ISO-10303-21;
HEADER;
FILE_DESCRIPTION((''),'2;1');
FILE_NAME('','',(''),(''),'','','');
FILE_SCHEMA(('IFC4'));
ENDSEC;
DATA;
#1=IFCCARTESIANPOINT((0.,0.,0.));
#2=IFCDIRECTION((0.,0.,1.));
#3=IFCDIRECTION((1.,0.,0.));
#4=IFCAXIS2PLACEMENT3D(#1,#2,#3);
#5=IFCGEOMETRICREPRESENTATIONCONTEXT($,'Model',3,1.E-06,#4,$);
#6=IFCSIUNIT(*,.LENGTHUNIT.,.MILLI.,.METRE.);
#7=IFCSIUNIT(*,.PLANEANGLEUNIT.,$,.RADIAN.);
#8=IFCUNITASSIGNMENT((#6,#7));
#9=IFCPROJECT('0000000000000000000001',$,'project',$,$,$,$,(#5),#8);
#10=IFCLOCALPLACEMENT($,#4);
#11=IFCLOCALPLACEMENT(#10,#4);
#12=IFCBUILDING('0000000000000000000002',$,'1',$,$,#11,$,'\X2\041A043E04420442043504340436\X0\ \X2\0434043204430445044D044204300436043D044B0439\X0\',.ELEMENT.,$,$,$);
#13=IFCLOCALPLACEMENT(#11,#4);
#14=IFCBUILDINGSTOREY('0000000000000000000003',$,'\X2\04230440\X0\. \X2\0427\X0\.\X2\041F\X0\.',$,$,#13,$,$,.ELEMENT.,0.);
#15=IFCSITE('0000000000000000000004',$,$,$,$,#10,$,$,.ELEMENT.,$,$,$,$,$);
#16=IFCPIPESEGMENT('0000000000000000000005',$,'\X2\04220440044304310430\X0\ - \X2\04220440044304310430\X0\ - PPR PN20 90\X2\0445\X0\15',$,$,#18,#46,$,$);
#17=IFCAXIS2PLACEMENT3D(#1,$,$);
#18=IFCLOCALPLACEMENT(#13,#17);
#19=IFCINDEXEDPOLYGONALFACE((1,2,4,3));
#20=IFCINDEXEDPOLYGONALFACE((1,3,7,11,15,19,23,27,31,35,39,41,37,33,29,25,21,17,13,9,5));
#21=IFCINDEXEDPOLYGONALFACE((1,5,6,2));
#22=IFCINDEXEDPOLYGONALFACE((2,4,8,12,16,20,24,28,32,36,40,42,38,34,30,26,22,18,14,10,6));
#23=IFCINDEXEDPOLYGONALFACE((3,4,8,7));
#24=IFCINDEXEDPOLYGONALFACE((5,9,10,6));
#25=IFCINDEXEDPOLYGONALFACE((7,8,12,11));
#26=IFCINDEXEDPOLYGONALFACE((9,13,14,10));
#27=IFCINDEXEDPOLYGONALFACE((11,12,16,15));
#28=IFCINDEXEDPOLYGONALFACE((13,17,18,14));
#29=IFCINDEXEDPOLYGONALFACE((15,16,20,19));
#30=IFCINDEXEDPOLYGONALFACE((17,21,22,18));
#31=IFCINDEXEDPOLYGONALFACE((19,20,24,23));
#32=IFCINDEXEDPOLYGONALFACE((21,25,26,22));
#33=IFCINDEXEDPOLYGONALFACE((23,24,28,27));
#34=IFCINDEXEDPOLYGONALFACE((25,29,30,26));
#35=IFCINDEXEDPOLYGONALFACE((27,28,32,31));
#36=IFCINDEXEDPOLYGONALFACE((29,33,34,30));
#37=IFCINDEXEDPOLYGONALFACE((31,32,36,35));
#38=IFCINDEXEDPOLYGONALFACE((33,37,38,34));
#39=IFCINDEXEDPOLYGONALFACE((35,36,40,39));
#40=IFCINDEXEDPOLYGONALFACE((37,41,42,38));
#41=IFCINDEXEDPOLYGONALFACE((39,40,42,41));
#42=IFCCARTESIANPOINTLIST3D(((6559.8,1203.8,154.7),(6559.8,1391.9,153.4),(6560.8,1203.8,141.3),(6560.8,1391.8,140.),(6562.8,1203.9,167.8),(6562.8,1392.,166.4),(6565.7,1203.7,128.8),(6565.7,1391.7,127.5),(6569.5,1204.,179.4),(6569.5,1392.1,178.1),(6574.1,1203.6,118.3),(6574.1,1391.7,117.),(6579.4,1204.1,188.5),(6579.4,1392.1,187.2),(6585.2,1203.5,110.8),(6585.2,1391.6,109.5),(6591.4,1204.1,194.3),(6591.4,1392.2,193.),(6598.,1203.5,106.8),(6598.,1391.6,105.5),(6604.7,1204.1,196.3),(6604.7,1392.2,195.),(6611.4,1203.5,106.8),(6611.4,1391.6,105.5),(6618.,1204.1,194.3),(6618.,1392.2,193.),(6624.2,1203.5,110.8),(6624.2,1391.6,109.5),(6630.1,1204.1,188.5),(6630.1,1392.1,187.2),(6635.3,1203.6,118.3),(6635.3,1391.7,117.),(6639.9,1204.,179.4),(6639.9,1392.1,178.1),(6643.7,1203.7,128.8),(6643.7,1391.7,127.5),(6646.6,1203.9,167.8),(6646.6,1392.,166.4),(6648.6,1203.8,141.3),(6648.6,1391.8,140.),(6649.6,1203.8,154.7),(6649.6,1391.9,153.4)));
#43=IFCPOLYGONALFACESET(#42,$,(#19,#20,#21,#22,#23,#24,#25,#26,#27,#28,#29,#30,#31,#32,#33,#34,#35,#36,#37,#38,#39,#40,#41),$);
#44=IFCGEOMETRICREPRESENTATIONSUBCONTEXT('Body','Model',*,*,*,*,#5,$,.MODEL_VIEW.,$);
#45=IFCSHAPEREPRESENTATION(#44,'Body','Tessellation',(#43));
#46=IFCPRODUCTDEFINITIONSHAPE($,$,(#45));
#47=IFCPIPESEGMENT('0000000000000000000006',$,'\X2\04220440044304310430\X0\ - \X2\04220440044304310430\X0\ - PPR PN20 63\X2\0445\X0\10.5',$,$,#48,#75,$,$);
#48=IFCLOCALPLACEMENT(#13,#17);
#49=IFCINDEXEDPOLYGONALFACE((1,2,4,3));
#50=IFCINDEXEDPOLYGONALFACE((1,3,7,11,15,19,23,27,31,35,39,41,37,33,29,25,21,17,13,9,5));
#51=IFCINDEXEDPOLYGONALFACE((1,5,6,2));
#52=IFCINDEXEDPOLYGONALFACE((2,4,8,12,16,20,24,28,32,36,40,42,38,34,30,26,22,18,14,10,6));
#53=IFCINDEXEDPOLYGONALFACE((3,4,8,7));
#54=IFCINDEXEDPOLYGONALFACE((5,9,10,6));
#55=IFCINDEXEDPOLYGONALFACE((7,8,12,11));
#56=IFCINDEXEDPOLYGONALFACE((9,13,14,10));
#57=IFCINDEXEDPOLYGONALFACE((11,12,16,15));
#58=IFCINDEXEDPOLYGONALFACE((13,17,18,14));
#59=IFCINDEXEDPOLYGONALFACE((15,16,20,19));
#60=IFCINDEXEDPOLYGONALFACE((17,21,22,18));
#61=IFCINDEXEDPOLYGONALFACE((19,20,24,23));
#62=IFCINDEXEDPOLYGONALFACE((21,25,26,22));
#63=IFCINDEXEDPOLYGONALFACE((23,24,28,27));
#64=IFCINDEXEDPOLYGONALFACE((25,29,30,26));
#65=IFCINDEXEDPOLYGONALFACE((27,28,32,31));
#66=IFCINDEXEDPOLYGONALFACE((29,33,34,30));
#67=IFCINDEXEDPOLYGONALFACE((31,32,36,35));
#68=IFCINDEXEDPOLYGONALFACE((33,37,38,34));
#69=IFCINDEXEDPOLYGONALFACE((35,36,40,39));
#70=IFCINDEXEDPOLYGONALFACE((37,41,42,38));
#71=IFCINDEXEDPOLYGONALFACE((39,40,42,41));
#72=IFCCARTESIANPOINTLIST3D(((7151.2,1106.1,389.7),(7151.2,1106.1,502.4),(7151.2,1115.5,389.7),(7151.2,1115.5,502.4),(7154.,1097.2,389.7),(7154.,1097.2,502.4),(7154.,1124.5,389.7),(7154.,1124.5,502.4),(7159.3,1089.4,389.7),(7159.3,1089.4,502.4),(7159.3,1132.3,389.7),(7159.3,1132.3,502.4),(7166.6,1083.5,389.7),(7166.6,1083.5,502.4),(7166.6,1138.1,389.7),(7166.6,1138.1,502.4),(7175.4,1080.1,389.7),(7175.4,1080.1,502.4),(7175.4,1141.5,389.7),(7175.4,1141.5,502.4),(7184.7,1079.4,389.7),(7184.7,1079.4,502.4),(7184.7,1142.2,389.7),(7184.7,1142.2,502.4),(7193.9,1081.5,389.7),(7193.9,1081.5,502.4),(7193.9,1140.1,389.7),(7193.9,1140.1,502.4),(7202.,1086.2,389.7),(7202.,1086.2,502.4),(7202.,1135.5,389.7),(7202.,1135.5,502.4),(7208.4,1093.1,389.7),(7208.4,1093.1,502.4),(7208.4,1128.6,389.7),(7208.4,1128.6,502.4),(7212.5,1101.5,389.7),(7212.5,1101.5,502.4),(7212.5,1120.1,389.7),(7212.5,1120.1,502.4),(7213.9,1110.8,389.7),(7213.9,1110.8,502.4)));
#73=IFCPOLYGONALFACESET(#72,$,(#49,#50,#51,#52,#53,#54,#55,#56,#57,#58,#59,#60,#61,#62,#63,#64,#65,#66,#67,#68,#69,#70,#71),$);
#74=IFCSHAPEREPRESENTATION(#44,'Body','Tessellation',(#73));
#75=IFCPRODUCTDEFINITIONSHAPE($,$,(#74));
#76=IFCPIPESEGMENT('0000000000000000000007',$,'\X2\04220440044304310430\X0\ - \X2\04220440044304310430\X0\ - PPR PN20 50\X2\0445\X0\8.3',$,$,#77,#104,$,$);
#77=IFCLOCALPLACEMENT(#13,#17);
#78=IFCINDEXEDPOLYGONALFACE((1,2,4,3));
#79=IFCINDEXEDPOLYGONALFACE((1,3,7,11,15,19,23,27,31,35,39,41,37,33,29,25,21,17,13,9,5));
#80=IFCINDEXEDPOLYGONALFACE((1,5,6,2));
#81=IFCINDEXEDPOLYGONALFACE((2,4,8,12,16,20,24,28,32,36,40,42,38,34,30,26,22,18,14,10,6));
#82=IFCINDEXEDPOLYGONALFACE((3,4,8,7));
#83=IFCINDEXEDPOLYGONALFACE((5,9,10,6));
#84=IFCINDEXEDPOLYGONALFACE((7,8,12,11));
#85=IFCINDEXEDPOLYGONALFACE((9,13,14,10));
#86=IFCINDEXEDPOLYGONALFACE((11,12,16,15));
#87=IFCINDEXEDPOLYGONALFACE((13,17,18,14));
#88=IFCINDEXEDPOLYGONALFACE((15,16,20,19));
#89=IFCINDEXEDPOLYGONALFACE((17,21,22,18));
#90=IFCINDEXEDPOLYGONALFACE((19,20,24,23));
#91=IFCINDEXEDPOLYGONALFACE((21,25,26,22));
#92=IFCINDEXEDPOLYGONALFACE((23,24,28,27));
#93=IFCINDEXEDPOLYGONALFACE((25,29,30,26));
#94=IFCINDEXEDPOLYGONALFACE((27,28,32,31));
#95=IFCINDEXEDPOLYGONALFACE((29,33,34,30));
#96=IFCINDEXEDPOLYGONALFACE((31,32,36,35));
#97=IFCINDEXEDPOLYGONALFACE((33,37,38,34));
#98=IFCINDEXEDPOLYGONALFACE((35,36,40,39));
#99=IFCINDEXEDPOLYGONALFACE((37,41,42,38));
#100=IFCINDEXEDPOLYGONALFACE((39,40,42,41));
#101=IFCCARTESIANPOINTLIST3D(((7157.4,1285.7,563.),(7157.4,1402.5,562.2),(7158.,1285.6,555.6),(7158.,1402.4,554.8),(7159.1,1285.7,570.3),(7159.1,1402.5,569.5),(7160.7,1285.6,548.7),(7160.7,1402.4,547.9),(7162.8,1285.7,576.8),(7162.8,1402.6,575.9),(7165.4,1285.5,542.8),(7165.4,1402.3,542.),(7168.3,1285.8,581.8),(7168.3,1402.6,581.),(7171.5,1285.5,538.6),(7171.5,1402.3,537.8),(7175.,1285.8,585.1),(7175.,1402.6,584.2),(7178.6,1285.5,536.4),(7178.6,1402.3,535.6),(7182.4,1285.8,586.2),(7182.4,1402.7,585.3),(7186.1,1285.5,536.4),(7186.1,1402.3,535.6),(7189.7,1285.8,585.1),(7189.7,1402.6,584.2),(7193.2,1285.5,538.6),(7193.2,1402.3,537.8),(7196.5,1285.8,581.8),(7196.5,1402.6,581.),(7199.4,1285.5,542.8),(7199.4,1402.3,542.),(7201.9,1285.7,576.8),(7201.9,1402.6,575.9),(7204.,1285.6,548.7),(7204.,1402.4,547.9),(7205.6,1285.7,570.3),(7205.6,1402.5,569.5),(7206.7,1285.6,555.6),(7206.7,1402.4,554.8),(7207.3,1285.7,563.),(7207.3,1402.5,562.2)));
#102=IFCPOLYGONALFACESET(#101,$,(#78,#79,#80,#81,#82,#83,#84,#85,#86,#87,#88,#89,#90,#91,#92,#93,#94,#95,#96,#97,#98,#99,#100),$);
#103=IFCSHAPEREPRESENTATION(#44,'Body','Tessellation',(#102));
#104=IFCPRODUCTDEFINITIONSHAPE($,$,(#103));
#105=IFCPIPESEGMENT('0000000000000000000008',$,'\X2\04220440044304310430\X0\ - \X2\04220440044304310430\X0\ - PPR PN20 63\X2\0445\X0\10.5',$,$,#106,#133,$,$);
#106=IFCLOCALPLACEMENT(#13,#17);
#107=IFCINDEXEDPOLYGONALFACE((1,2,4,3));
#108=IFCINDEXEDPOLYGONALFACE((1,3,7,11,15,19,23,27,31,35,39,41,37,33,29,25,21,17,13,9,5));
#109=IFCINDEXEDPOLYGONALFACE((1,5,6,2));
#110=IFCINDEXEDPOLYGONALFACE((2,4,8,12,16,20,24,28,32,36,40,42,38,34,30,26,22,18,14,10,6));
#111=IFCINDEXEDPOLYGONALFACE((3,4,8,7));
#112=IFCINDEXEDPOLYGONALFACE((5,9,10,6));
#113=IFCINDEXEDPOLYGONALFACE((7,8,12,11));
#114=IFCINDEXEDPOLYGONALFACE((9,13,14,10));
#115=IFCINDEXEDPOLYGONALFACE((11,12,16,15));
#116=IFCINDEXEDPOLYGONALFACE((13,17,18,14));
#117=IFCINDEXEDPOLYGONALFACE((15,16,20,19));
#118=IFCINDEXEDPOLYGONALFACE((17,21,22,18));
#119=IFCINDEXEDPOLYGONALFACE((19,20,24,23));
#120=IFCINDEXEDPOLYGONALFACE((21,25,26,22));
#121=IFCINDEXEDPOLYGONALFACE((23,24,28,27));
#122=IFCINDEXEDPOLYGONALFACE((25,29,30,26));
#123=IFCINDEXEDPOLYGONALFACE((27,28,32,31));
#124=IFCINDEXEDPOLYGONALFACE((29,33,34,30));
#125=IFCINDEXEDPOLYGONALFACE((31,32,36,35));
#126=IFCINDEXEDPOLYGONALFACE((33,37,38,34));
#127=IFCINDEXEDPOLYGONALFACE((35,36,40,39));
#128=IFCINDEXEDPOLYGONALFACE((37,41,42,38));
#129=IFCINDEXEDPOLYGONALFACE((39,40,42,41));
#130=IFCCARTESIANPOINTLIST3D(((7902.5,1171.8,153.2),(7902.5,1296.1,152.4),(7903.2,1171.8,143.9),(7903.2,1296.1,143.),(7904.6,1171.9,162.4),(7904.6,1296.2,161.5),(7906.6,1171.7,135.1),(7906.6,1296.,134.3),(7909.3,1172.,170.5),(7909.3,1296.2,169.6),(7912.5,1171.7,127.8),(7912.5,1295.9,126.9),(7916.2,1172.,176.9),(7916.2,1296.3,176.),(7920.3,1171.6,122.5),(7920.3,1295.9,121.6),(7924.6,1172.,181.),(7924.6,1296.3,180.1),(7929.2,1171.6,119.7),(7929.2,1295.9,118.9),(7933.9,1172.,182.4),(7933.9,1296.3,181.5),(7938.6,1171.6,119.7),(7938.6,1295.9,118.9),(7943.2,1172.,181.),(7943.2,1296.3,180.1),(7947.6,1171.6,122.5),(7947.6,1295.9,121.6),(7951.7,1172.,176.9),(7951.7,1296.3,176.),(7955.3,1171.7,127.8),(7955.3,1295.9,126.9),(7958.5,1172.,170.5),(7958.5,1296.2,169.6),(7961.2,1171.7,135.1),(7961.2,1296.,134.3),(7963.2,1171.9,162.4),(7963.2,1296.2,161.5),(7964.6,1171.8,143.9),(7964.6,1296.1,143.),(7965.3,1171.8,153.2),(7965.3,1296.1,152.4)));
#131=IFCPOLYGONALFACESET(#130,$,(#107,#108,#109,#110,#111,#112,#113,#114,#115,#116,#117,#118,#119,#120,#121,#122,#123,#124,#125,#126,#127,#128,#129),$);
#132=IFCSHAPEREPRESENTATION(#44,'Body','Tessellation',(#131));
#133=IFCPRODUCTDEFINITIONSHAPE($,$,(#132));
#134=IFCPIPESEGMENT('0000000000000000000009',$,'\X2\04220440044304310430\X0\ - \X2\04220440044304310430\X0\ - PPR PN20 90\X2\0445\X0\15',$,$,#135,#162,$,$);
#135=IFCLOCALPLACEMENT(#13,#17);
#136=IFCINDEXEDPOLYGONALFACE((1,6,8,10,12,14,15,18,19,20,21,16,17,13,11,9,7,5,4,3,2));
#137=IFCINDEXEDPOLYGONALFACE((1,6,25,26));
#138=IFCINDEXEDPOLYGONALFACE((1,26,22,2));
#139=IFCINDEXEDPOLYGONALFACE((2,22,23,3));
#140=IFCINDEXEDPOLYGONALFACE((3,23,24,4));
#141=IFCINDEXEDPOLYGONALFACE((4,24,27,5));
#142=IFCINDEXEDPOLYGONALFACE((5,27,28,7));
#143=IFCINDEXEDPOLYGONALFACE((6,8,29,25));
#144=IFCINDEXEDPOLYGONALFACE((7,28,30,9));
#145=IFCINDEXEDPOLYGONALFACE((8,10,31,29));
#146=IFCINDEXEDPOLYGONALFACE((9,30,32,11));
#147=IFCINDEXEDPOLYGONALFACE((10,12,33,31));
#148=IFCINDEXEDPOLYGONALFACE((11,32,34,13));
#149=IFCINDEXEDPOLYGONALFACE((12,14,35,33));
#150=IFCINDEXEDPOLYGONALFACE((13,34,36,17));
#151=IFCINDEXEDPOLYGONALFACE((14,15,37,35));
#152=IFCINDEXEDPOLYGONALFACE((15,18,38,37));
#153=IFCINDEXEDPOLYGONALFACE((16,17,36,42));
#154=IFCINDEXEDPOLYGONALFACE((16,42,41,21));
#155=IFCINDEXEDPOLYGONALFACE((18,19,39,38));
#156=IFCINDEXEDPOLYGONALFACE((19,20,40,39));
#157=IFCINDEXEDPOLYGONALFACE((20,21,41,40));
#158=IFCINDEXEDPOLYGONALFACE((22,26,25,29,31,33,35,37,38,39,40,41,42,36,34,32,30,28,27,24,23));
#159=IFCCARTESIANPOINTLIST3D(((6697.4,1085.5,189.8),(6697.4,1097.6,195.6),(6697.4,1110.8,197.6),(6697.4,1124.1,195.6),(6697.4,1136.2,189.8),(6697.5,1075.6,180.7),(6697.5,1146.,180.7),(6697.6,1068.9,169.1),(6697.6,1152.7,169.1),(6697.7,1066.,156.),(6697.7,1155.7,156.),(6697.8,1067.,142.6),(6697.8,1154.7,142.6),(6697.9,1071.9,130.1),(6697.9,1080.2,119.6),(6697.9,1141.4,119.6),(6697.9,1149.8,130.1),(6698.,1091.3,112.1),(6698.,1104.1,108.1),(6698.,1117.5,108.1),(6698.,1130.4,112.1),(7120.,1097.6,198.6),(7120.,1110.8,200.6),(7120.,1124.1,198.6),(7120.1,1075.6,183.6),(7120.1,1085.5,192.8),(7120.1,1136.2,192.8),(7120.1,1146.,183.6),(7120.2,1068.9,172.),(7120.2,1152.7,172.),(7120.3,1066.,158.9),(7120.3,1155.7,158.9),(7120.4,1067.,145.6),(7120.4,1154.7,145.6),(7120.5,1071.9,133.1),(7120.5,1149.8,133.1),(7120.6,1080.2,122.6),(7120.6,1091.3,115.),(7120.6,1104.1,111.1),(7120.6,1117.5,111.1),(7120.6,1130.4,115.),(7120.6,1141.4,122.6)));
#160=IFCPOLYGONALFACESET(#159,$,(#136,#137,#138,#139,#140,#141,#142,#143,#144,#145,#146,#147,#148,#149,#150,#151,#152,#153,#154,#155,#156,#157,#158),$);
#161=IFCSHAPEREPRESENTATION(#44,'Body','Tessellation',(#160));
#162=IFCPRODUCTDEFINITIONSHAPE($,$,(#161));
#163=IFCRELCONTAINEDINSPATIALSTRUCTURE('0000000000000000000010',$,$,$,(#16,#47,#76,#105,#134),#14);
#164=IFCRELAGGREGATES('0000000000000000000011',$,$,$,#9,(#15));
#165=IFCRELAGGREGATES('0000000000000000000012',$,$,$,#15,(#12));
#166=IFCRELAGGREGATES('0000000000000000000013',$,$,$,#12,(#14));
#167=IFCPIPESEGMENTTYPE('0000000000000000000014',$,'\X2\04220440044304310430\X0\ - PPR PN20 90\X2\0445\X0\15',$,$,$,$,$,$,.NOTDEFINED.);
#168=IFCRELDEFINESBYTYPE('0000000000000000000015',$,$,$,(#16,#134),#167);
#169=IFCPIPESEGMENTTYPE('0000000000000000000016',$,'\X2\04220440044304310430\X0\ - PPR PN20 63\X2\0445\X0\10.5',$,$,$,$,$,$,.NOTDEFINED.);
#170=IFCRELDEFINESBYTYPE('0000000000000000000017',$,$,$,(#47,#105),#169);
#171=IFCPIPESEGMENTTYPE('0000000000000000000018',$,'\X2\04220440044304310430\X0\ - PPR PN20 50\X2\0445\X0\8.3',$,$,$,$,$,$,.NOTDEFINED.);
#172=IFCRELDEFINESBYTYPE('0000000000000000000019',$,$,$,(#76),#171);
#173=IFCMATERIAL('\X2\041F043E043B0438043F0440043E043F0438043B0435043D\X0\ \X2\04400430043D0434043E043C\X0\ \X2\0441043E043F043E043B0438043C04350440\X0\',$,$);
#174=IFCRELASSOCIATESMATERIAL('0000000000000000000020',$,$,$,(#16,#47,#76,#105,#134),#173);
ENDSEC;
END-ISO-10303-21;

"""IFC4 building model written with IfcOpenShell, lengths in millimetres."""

from ifc_helpers import new_model, entity, si_unit, frame, origin_with_axes, place, context, subcontext, project, spatial, source, transform, mapped, material, type_object, element, save


model = new_model("IFC4")

# Units and contexts
model_context = context("Model", 3, precision=1e-06, world=origin_with_axes())
body_context = subcontext(model_context, "Body", "Model", "MODEL_VIEW")
ifc_project = project(units=[si_unit("LENGTHUNIT", "METRE", prefix="MILLI"), si_unit("PLANEANGLEUNIT", "RADIAN")], contexts=[model_context])

# Site, building, storey
site_placement = place(None, origin_with_axes())
site = spatial("IfcSite", under=ifc_project, at=site_placement, CompositionType="ELEMENT")
building_placement = place(site_placement, origin_with_axes())
building = spatial("IfcBuilding", under=site, at=building_placement, Name="1", LongName="Коттедж двухэтажный", CompositionType="ELEMENT")
storey_placement = place(building_placement, origin_with_axes())
storey = spatial("IfcBuildingStorey", under=building, at=storey_placement, Name="Ур. Ч.П.", CompositionType="ELEMENT", Elevation=0.0)

# Pipe segments
ifc_material = material(Name="Полипропилен рандом сополимер")
pipe_segment_type_1 = type_object("IfcPipeSegmentType", Name="Труба - PPR PN20 90х15", PredefinedType="NOTDEFINED")
pipe_segment_type_2 = type_object("IfcPipeSegmentType", Name="Труба - PPR PN20 50х8.3", PredefinedType="NOTDEFINED")
pipe_segment_type_3 = type_object("IfcPipeSegmentType", Name="Труба - PPR PN20 63х10.5", PredefinedType="NOTDEFINED")
shared_shape_1 = source(origin_with_axes(), body_context, "Body", "AdvancedSweptSolid", [
    entity("IfcSweptDiskSolid", entity("IfcIndexedPolyCurve", entity("IfcCartesianPointList3D", [[0.0, 0.0, 0.0], [188.1, 0.0, 1.3]]), [entity("IfcLineIndex", [1, 2])]), 45.0),
])
pipe_segment_1_placement = place(storey_placement, frame((6604.7, 1391.9, 150.0), z_axis=(0.0, 0.0, 1.0), x_axis=(0.0, -1.0, 0.0)))
element("IfcPipeSegment", 1, at=pipe_segment_1_placement, inside=storey, type_object=pipe_segment_type_1, material=ifc_material, Name="Труба - Труба - PPR PN20 90х15", context=body_context, shape_type="MappedRepresentation", body=[
    mapped(shared_shape_1, transform((0.0, 0.0, 0.0), x_axis=(1.0, 0.0, 0.0), y_axis=(0.0, 1.0, 0.0), z_axis=(0.0, 0.0, 1.0), scale=1.0)),
])
shared_shape_2 = source(origin_with_axes(), body_context, "Body", "AdvancedSweptSolid", [
    entity("IfcSweptDiskSolid", entity("IfcIndexedPolyCurve", entity("IfcCartesianPointList3D", [[0.0, 0.0, 0.0], [0.0, 0.0, -112.7]]), [entity("IfcLineIndex", [1, 2])]), 31.5),
])
pipe_segment_2_placement = place(storey_placement, frame((7182.4, 1110.8, 502.4), z_axis=(0.0, 0.0, 1.0), x_axis=(-1.0, 0.0, 0.0)))
element("IfcPipeSegment", 2, at=pipe_segment_2_placement, inside=storey, type_object=pipe_segment_type_3, material=ifc_material, Name="Труба - Труба - PPR PN20 63х10.5", context=body_context, shape_type="MappedRepresentation", body=[
    mapped(shared_shape_2, transform((0.0, 0.0, 0.0), x_axis=(1.0, 0.0, 0.0), y_axis=(0.0, 1.0, 0.0), z_axis=(0.0, 0.0, 1.0), scale=1.0)),
])
shared_shape_3 = source(origin_with_axes(), body_context, "Body", "AdvancedSweptSolid", [
    entity("IfcSweptDiskSolid", entity("IfcIndexedPolyCurve", entity("IfcCartesianPointList3D", [[0.0, 0.0, 0.0], [116.8, 0.0, 0.8]]), [entity("IfcLineIndex", [1, 2])]), 25.0),
])
pipe_segment_3_placement = place(storey_placement, frame((7182.4, 1402.5, 560.3), z_axis=(0.0, 0.0, 1.0), x_axis=(0.0, -1.0, 0.0)))
element("IfcPipeSegment", 3, at=pipe_segment_3_placement, inside=storey, type_object=pipe_segment_type_2, material=ifc_material, Name="Труба - Труба - PPR PN20 50х8.3", context=body_context, shape_type="MappedRepresentation", body=[
    mapped(shared_shape_3, transform((0.0, 0.0, 0.0), x_axis=(1.0, 0.0, 0.0), y_axis=(0.0, 1.0, 0.0), z_axis=(0.0, 0.0, 1.0), scale=1.0)),
])
shared_shape_4 = source(origin_with_axes(), body_context, "Body", "AdvancedSweptSolid", [
    entity("IfcSweptDiskSolid", entity("IfcIndexedPolyCurve", entity("IfcCartesianPointList3D", [[0.0, 0.0, 0.0], [124.3, 0.0, 0.9]]), [entity("IfcLineIndex", [1, 2])]), 31.5),
])
pipe_segment_4_placement = place(storey_placement, frame((7933.9, 1296.1, 150.0), z_axis=(0.0, 0.0, 1.0), x_axis=(0.0, -1.0, 0.0)))
element("IfcPipeSegment", 4, at=pipe_segment_4_placement, inside=storey, type_object=pipe_segment_type_3, material=ifc_material, Name="Труба - Труба - PPR PN20 63х10.5", context=body_context, shape_type="MappedRepresentation", body=[
    mapped(shared_shape_4, transform((0.0, 0.0, 0.0), x_axis=(1.0, 0.0, 0.0), y_axis=(0.0, 1.0, 0.0), z_axis=(0.0, 0.0, 1.0), scale=1.0)),
])
shared_shape_5 = source(origin_with_axes(), body_context, "Body", "AdvancedSweptSolid", [
    entity("IfcSweptDiskSolid", entity("IfcIndexedPolyCurve", entity("IfcCartesianPointList3D", [[0.0, 0.0, 0.0], [422.6, 0.0, 3.0]]), [entity("IfcLineIndex", [1, 2])]), 45.0),
])
pipe_segment_5_placement = place(storey_placement, frame((6697.7, 1110.8, 152.6), z_axis=(0.0, 0.0, 1.0), x_axis=(1.0, 0.0, 0.0)))
element("IfcPipeSegment", 5, at=pipe_segment_5_placement, inside=storey, type_object=pipe_segment_type_1, material=ifc_material, Name="Труба - Труба - PPR PN20 90х15", context=body_context, shape_type="MappedRepresentation", body=[
    mapped(shared_shape_5, transform((0.0, 0.0, 0.0), x_axis=(1.0, 0.0, 0.0), y_axis=(0.0, 1.0, 0.0), z_axis=(0.0, 0.0, 1.0), scale=1.0)),
])

save(model, "model.ifc")
